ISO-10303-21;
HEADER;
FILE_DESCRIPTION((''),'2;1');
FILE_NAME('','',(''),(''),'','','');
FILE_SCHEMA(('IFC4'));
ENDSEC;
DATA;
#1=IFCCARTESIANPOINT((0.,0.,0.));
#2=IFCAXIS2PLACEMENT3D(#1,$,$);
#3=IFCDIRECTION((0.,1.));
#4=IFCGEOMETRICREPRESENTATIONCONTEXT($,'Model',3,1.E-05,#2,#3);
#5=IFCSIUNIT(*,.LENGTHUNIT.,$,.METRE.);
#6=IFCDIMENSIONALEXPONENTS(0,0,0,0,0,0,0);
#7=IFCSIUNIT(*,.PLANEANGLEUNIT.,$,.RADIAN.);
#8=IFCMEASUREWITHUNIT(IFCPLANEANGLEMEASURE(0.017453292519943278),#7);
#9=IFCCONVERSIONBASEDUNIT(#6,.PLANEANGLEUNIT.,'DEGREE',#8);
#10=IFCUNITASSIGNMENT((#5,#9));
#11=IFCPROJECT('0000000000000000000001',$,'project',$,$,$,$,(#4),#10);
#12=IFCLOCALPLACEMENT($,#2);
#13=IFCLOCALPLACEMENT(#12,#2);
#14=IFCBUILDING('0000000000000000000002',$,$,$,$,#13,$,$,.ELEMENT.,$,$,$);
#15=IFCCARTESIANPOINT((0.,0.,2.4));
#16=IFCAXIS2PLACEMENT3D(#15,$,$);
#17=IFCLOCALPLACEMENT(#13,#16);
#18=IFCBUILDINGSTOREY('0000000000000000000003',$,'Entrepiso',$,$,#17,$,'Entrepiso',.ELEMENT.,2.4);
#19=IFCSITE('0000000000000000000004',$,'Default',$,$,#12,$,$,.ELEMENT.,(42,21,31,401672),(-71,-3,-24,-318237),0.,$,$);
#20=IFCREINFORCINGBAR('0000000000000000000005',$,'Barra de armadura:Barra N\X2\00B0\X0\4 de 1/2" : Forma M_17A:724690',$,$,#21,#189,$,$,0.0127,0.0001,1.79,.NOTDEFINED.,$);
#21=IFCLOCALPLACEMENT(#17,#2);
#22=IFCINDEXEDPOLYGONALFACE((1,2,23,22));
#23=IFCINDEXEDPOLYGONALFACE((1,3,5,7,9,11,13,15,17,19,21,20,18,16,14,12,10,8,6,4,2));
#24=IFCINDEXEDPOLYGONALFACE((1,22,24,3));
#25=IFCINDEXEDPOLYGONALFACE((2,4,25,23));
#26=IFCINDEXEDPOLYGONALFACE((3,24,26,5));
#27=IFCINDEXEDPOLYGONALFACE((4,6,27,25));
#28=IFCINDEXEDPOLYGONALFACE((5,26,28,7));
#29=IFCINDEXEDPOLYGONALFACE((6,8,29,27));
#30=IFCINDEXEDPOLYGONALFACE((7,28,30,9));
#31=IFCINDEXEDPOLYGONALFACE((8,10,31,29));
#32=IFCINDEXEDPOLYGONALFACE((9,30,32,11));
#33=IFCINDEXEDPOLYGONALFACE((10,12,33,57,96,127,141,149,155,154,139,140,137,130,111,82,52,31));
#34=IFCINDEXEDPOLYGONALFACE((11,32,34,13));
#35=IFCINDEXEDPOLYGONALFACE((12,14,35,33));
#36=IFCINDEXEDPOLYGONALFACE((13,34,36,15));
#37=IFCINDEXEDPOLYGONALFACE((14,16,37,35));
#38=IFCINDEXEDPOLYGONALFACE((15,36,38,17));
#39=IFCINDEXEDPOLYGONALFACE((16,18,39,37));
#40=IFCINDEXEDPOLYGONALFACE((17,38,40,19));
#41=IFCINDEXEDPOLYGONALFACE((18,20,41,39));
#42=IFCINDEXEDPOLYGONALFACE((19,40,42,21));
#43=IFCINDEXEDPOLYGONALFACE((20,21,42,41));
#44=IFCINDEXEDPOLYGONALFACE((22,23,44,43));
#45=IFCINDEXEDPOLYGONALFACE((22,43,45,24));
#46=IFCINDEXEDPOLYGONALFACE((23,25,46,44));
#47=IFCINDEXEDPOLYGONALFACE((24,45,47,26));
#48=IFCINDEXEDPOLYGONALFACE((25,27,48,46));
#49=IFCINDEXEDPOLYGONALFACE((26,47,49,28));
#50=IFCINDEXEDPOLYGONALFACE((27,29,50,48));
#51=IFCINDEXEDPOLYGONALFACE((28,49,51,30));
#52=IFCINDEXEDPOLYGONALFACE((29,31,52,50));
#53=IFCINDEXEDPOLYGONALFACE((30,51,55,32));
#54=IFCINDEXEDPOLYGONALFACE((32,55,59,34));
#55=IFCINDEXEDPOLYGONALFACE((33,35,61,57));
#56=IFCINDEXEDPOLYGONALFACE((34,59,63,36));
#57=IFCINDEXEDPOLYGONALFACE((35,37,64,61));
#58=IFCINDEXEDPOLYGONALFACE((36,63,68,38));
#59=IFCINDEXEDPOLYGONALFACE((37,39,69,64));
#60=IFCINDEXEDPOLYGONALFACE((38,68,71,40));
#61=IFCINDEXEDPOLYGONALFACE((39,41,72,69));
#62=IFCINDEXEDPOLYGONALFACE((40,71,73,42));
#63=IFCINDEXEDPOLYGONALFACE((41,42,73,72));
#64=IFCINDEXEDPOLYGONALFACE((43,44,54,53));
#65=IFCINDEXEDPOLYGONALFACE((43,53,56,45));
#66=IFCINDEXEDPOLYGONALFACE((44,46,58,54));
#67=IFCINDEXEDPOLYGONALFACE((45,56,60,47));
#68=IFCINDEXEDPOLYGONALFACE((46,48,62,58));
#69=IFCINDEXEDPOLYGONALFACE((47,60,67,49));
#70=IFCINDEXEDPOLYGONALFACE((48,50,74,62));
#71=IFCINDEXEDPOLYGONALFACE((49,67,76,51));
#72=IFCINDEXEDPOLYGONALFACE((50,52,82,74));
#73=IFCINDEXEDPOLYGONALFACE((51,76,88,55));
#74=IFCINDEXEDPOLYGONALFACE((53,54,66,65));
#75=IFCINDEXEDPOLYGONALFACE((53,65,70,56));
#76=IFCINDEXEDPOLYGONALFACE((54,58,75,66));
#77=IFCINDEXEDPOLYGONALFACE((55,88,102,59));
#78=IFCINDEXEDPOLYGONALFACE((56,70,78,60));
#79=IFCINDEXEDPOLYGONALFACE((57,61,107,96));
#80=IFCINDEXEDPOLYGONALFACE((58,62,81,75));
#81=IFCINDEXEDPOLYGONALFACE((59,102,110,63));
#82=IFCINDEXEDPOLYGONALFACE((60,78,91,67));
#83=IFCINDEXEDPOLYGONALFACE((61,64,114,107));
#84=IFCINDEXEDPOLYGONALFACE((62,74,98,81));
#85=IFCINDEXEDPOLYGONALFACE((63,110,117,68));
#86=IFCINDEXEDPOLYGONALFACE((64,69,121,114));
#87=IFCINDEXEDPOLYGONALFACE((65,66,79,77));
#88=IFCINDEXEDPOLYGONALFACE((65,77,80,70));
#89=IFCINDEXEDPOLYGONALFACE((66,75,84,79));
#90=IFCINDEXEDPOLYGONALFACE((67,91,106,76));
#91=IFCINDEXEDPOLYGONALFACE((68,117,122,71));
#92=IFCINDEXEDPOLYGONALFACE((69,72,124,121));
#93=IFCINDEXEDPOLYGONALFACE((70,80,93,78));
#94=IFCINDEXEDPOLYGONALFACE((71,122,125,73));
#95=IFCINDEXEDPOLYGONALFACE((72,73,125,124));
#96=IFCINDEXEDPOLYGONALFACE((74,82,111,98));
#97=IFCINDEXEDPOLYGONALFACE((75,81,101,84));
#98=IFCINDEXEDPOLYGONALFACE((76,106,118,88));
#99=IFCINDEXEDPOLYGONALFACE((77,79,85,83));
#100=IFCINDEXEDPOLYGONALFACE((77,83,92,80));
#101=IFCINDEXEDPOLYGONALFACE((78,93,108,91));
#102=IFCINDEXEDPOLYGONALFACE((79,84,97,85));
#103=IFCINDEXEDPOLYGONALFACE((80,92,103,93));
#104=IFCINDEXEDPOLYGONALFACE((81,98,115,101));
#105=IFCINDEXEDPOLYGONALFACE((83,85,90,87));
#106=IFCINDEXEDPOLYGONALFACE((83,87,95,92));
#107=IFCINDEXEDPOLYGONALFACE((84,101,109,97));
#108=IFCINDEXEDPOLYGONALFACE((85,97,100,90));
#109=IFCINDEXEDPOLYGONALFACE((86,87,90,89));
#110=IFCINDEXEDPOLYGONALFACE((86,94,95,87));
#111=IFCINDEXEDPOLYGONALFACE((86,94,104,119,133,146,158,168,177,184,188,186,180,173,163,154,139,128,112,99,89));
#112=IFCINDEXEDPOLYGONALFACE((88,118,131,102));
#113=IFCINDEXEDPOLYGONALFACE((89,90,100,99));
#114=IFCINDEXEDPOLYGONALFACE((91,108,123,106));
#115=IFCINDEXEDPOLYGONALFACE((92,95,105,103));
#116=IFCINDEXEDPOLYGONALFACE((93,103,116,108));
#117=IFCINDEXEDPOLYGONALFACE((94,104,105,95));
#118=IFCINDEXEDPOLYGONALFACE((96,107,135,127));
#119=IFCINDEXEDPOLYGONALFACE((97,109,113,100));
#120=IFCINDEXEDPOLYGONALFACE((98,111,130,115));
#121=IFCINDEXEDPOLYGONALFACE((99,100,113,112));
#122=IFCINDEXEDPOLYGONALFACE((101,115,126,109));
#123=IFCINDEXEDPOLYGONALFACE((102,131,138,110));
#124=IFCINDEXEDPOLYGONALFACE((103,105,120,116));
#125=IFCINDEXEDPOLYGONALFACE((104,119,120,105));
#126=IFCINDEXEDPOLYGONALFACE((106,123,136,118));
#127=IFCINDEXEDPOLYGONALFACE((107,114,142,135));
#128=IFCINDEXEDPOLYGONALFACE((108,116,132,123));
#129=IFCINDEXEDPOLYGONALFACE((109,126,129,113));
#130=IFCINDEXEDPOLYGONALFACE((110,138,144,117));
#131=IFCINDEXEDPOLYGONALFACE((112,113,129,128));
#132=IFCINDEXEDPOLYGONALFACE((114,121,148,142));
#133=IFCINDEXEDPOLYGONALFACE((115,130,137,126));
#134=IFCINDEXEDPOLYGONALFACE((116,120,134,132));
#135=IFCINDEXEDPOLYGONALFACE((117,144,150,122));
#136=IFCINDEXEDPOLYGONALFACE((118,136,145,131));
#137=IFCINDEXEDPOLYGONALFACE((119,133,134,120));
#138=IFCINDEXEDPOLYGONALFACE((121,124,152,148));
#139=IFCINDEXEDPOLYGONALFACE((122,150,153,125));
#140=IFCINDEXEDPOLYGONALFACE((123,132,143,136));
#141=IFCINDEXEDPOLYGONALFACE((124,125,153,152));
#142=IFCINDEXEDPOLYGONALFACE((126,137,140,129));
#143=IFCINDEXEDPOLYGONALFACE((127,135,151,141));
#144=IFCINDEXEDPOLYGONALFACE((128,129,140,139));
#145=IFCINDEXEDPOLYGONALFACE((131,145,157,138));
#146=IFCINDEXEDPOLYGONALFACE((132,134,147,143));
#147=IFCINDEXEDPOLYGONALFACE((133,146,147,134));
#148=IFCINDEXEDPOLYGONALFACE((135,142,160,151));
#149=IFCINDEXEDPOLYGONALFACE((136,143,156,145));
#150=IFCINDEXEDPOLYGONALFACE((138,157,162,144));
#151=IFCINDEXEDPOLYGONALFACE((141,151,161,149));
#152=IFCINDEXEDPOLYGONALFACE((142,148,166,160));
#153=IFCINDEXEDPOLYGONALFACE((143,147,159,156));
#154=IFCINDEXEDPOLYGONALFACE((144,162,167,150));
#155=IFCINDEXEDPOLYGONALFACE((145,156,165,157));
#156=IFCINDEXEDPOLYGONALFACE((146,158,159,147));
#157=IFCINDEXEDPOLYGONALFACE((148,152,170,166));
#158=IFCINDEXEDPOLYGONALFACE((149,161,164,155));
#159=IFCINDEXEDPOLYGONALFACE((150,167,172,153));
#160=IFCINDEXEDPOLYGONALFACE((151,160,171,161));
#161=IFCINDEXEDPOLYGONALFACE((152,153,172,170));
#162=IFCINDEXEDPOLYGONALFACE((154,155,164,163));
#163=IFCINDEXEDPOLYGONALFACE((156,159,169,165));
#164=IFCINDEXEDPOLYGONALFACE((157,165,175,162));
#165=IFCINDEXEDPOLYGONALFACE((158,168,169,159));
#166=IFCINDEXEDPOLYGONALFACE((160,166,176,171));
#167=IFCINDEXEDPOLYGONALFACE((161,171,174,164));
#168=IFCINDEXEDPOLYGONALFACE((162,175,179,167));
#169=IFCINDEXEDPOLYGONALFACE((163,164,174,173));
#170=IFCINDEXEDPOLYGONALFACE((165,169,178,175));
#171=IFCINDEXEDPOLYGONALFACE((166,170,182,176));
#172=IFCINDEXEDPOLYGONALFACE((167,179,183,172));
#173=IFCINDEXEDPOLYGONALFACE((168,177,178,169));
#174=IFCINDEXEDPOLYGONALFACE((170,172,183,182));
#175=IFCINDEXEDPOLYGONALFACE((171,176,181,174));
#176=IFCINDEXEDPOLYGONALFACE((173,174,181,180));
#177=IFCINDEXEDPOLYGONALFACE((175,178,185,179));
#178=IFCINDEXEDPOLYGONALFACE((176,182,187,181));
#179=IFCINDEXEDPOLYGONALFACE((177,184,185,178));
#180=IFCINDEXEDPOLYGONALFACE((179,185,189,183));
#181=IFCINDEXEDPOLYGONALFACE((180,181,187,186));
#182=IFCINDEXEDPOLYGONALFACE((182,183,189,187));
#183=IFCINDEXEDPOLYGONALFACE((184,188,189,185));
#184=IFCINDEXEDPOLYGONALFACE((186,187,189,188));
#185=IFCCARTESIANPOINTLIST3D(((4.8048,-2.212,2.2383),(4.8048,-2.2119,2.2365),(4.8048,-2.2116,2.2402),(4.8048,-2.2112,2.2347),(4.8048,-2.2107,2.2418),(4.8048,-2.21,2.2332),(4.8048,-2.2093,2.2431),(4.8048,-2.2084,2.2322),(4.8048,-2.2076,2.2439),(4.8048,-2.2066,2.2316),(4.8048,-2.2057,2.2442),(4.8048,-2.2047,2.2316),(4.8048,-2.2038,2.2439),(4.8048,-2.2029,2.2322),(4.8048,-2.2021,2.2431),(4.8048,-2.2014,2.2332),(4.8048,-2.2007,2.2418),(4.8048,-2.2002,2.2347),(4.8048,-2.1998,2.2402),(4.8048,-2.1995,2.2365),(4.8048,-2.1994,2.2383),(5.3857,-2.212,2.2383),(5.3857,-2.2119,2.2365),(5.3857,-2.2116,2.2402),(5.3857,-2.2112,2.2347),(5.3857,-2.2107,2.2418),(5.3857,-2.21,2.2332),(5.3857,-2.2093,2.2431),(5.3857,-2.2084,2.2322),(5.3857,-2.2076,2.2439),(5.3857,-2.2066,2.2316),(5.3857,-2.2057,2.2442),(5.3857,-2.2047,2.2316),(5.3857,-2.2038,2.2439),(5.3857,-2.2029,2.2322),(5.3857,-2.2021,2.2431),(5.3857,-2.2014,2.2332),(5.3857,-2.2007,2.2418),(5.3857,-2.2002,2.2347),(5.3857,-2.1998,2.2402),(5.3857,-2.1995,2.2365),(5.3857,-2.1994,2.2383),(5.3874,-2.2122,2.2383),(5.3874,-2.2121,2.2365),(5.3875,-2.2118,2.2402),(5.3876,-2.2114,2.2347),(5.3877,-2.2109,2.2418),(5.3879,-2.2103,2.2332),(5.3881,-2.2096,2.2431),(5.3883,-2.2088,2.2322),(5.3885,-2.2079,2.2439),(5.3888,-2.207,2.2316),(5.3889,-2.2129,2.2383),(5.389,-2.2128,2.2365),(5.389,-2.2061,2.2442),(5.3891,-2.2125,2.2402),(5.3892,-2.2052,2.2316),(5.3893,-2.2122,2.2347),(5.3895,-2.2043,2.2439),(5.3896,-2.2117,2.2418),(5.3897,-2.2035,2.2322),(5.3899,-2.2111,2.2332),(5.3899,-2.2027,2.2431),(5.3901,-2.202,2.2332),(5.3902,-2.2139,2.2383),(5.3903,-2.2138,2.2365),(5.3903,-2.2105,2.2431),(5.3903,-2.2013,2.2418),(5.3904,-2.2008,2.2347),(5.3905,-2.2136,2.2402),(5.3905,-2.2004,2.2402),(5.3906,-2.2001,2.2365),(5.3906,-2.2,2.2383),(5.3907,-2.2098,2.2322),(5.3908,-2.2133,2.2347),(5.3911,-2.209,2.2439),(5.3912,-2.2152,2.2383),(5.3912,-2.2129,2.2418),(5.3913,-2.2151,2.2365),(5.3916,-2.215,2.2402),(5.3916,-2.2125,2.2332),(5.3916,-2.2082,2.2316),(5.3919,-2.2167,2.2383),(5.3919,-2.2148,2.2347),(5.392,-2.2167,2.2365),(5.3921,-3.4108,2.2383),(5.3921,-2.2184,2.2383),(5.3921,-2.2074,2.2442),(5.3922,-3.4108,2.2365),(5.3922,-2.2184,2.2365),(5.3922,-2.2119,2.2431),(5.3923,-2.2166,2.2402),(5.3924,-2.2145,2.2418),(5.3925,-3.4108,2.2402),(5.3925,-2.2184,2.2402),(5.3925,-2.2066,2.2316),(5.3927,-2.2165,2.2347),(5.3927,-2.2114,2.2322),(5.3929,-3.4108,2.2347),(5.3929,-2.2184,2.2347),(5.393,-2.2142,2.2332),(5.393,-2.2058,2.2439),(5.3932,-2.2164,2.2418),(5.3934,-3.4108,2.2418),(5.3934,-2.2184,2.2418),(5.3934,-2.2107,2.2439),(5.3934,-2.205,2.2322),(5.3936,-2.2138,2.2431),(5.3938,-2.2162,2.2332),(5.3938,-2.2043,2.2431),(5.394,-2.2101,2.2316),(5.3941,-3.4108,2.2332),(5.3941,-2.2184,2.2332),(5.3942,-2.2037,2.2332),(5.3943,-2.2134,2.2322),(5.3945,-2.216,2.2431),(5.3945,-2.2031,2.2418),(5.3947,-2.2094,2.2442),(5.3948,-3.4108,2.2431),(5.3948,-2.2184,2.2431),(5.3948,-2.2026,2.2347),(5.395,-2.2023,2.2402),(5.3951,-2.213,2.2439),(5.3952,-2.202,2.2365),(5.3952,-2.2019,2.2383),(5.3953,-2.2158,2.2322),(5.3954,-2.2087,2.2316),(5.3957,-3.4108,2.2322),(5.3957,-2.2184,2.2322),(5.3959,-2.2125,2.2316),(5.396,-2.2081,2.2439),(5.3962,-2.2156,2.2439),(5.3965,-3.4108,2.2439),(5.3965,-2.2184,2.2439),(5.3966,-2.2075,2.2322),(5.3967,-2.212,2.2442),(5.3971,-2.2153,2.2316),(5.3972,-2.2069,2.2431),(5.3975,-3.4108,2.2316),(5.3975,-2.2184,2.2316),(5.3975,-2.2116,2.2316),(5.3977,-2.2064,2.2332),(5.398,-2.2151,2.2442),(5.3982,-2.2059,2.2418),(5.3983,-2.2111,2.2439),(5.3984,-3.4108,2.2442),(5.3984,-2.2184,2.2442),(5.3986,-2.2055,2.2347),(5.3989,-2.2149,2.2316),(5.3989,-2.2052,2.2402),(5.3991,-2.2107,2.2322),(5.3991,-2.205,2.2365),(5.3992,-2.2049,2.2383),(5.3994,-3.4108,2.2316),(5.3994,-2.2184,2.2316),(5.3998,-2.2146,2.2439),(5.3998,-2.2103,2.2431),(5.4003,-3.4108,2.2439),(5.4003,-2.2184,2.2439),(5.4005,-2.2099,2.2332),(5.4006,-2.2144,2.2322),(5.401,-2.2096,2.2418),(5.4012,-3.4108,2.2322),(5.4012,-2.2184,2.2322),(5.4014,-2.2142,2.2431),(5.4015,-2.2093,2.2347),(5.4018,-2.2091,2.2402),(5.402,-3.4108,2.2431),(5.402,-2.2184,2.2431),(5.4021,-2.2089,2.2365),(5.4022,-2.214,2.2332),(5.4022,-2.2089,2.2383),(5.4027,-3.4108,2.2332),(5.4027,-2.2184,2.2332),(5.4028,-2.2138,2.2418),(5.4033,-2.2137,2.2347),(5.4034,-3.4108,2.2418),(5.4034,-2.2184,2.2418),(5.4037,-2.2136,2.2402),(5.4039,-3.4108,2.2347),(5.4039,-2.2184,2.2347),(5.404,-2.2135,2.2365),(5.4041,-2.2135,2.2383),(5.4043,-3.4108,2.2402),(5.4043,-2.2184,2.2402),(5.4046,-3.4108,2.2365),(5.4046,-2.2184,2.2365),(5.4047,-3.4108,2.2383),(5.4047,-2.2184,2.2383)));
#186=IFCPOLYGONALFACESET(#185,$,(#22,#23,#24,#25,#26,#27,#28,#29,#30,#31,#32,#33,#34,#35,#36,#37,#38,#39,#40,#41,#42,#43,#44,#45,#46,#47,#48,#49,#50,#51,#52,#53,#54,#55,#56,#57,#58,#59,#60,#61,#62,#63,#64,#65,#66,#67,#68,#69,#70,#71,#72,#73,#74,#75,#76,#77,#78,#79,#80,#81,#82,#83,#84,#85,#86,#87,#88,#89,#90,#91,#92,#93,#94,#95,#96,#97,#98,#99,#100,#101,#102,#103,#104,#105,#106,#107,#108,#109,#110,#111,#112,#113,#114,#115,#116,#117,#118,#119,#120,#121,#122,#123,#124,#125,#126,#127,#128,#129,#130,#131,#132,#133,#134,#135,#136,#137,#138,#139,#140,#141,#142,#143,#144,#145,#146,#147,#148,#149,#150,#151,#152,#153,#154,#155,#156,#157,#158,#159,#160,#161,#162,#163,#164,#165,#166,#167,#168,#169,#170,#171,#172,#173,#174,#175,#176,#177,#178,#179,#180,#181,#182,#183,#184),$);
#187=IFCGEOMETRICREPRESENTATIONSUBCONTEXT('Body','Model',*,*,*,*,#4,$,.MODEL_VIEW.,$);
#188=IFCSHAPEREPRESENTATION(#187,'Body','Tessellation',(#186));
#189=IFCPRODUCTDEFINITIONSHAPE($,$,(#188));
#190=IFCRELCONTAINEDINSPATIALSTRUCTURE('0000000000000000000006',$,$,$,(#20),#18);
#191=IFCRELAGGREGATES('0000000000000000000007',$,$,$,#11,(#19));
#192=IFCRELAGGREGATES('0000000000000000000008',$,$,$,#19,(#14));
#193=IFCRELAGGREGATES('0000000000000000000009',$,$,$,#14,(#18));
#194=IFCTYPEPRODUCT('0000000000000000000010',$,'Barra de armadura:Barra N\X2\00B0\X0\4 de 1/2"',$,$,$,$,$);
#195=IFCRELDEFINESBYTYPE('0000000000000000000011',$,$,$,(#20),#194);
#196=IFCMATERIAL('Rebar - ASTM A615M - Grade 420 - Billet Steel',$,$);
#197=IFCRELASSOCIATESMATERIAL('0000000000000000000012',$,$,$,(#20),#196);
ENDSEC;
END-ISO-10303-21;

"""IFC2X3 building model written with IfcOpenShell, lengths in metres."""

from ifc_helpers import new_model, entity, si_unit, converted_unit, direction, frame, origin, place, context, subcontext, project, spatial, material, type_object, element, save


model = new_model("IFC2X3")

# Units and contexts
model_context = context("Model", 3, precision=1e-05, world=origin(), true_north=direction((0.0, 1.0)))
body_context = subcontext(model_context, "Body", "Model", "MODEL_VIEW")
ifc_project = project(units=[si_unit("LENGTHUNIT", "METRE"), converted_unit("PLANEANGLEUNIT", "DEGREE", entity("IfcPlaneAngleMeasure", 0.017453292519943278), si_unit("PLANEANGLEUNIT", "RADIAN"), dimensions=[0, 0, 0, 0, 0, 0, 0])], contexts=[model_context])

# Site, building, storey
site_placement = place(None, origin())
site = spatial("IfcSite", under=ifc_project, at=site_placement, Name="Default", CompositionType="ELEMENT", RefLatitude=(42, 21, 31, 401672), RefLongitude=(-71, -3, -24, -318237), RefElevation=0.0)
building_placement = place(site_placement, origin())
building = spatial("IfcBuilding", under=site, at=building_placement, CompositionType="ELEMENT")
storey_placement = place(building_placement, frame((0.0, 0.0, 2.4)))
storey = spatial("IfcBuildingStorey", under=building, at=storey_placement, Name="Entrepiso", LongName="Entrepiso", CompositionType="ELEMENT", Elevation=2.4)

# Reinforcing bar
ifc_material = material(Name="Rebar - ASTM A615M - Grade 420 - Billet Steel")
type_product_1 = type_object("IfcTypeProduct", Name="Barra de armadura:Barra N°4 de 1/2\"")
reinforcing_bar_1_placement = place(storey_placement, origin())
element("IfcReinforcingBar", 1, at=reinforcing_bar_1_placement, inside=storey, type_object=type_product_1, material=ifc_material, Name="Barra de armadura:Barra N°4 de 1/2\" : Forma M_17A:724690", BarLength=1.79, BarRole="NOTDEFINED", CrossSectionArea=0.0001, NominalDiameter=0.0127, context=body_context, shape_type="AdvancedSweptSolid", body=[
    entity("IfcSweptDiskSolid", entity("IfcCompositeCurve", [entity("IfcCompositeCurveSegment", "CONTINUOUS", True, entity("IfcPolyline", [entity("IfcCartesianPoint", [5.3984, -3.4108, 2.2379]), entity("IfcCartesianPoint", [5.3984, -2.2184, 2.2379])])), entity("IfcCompositeCurveSegment", "CONTINUOUS", True, entity("IfcTrimmedCurve", entity("IfcCircle", entity("IfcAxis2Placement3D", entity("IfcCartesianPoint", [5.3857, -2.2184, 2.2379]), entity("IfcDirection", [0.0, 0.0, 1.0]), entity("IfcDirection", [0.0, 1.0, 0.0])), 0.0127), [entity("IfcParameterValue", 270.0)], [entity("IfcParameterValue", 360.0)], True, "PARAMETER")), entity("IfcCompositeCurveSegment", "CONTINUOUS", True, entity("IfcPolyline", [entity("IfcCartesianPoint", [5.3857, -2.2057, 2.2379]), entity("IfcCartesianPoint", [4.8048, -2.2057, 2.2379])]))], False), 0.0063, None, 0.0, 92.0),
])

save(model, "model.ifc")
